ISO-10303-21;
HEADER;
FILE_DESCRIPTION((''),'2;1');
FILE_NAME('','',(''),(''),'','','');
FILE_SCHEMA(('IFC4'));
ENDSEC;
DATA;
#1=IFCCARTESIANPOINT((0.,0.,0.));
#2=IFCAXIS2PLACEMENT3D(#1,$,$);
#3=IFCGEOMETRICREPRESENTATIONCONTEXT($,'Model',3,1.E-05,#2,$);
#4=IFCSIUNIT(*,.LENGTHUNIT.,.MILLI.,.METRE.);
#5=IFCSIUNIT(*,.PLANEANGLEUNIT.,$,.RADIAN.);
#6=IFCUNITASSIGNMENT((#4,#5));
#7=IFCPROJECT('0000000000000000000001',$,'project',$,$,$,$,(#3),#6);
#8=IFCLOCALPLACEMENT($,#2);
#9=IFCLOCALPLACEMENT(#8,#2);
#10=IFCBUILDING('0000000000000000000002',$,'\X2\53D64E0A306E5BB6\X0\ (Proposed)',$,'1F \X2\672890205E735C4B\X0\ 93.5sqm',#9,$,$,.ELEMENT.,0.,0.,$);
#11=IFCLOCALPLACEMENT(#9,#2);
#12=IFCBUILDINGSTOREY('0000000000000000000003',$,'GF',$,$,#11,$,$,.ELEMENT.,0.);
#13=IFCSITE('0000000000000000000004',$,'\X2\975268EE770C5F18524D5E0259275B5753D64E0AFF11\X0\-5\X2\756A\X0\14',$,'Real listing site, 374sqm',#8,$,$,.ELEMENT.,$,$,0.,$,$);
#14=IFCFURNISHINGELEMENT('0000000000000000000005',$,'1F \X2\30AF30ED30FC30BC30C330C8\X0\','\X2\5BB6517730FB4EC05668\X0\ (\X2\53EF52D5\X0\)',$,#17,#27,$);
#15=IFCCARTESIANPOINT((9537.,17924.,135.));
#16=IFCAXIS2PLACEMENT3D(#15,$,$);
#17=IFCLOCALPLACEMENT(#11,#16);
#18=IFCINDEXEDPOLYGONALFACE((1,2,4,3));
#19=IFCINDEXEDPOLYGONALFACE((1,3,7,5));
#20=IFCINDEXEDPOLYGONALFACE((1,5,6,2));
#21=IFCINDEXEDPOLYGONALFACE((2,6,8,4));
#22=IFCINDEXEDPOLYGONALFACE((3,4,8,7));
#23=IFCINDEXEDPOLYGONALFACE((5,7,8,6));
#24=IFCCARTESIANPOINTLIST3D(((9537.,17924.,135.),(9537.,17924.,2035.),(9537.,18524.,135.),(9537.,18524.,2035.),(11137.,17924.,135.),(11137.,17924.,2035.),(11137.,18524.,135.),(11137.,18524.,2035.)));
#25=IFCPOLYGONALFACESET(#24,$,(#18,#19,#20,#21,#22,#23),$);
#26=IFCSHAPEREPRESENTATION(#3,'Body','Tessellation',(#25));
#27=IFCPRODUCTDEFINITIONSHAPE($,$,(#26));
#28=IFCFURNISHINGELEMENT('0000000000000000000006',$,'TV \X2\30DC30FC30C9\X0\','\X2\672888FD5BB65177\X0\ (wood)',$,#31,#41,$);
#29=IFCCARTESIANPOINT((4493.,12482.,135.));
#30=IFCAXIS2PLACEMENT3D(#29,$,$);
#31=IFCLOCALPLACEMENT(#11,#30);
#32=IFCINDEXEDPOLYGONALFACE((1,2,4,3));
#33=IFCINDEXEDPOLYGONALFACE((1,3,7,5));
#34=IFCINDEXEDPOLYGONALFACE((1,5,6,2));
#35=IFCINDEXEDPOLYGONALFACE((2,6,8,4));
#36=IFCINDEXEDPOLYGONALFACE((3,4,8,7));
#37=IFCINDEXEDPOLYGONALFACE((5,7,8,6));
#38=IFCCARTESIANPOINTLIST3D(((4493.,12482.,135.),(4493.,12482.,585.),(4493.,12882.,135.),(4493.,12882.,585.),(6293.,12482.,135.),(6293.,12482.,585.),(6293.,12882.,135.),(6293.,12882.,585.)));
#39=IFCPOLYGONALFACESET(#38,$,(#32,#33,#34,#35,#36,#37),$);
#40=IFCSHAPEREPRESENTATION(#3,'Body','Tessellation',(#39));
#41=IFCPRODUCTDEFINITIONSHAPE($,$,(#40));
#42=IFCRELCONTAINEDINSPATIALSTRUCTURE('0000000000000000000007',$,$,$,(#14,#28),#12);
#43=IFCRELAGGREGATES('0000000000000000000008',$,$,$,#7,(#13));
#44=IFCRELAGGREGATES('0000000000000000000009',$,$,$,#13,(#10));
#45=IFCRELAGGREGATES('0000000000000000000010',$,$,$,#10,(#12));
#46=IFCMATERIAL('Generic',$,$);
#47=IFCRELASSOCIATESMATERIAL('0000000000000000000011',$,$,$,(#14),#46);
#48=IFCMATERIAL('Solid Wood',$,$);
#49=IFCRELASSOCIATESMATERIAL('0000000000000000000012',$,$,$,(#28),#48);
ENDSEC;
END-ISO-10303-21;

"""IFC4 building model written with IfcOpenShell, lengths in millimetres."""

from ifc_helpers import new_model, si_unit, frame, frame_2d, origin, place, context, project, spatial, rectangle, extrude, material, element, save


model = new_model("IFC4")

# Units and contexts
model_context = context("Model", 3, precision=1e-05, world=origin())
ifc_project = project(units=[si_unit("LENGTHUNIT", "METRE", prefix="MILLI"), si_unit("PLANEANGLEUNIT", "RADIAN")], contexts=[model_context])

# Site, building, storey
site_placement = place(None, origin())
site = spatial("IfcSite", under=ifc_project, at=site_placement, Name="青森県弘前市大字取上１-5番14", ObjectType="Real listing site, 374sqm", CompositionType="ELEMENT", RefElevation=0.0)
building_placement = place(site_placement, origin())
building = spatial("IfcBuilding", under=site, at=building_placement, Name="取上の家 (Proposed)", ObjectType="1F 木造平屋 93.5sqm", CompositionType="ELEMENT", ElevationOfRefHeight=0.0, ElevationOfTerrain=0.0)
storey_placement = place(building_placement, origin())
storey = spatial("IfcBuildingStorey", under=building, at=storey_placement, Name="GF", CompositionType="ELEMENT", Elevation=0.0)

# Shared definitions
ifc_material_1 = material(Name="Solid Wood")

# Shared definitions
ifc_material_2 = material(Name="Generic")

# Furnishing elements
furnishing_1_placement = place(storey_placement, frame((9537.0, 17924.0, 135.0)))
element("IfcFurnishingElement", 1, at=furnishing_1_placement, inside=storey, material=ifc_material_2, Name="1F クローゼット", Description="家具・什器 (可動)", context=model_context, shape_type="SweptSolid", body=[
    extrude(rectangle(XDim=1600.0, YDim=600.0, at=frame_2d((800.0, 300.0))), frame((9537.0, 17924.0, 135.0)), (0.0, 0.0, 1.0), 1900.0),
])
furnishing_2_placement = place(storey_placement, frame((4493.0, 12482.0, 135.0)))
element("IfcFurnishingElement", 2, at=furnishing_2_placement, inside=storey, material=ifc_material_1, Name="TV ボード", Description="木製家具 (wood)", context=model_context, shape_type="SweptSolid", body=[
    extrude(rectangle(XDim=1800.0, YDim=400.0, at=frame_2d((900.0, 200.0))), frame((4493.0, 12482.0, 135.0)), (0.0, 0.0, 1.0), 450.0),
])

save(model, "model.ifc")
